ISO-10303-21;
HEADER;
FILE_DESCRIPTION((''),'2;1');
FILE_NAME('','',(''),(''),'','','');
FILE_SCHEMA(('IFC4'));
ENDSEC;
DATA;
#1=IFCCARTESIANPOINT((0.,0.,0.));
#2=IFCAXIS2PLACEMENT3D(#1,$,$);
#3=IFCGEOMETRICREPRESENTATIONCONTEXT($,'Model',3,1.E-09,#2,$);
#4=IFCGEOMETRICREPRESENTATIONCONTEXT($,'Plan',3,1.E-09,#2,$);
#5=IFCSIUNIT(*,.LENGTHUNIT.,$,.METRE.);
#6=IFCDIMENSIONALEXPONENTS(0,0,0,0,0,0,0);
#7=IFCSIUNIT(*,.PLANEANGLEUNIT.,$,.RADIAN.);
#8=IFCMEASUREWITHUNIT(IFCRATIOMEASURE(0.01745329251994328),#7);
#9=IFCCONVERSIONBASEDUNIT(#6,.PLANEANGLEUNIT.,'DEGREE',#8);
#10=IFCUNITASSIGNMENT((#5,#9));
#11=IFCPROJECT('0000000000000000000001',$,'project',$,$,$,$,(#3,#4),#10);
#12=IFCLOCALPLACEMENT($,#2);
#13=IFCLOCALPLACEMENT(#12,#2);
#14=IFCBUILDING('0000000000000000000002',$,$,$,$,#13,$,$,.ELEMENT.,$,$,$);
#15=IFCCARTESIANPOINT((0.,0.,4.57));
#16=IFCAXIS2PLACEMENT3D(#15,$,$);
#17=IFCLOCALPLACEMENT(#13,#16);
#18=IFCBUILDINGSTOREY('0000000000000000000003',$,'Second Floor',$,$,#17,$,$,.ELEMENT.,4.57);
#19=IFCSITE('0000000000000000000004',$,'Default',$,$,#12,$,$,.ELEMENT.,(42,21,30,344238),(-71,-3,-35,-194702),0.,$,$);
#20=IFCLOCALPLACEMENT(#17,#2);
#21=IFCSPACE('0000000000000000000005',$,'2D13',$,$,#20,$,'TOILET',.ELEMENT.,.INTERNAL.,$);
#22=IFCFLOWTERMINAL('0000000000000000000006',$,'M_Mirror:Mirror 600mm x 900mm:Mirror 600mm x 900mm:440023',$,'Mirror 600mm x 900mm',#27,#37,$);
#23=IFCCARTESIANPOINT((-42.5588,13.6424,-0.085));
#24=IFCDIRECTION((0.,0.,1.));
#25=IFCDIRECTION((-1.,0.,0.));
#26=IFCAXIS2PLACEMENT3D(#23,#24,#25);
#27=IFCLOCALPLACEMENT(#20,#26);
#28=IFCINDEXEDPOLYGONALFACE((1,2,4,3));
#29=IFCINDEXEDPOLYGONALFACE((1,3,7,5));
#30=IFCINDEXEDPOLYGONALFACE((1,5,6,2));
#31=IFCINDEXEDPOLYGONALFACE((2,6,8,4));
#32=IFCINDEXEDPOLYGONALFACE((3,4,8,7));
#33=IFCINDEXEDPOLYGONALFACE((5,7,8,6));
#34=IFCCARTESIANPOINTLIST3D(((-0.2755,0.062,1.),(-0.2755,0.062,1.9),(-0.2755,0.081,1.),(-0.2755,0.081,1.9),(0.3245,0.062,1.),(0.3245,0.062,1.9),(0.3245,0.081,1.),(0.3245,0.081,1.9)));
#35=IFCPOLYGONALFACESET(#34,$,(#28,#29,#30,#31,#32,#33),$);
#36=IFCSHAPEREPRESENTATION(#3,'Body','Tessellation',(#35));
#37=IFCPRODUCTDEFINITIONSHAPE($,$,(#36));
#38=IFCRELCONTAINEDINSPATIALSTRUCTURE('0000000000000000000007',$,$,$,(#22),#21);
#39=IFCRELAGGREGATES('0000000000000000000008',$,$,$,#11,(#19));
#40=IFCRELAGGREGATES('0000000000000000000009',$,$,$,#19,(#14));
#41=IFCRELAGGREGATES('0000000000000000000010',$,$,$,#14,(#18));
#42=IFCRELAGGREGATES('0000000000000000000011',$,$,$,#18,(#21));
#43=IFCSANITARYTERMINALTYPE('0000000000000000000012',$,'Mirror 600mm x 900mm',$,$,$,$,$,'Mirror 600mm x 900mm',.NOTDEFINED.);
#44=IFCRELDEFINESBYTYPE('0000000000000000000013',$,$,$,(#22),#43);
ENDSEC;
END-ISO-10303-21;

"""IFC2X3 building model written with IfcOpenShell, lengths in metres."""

from ifc_helpers import new_model, entity, si_unit, converted_unit, frame, origin, origin_2d_with_axis, place, context, project, spatial, rectangle, extrude, source, transform, mapped, type_object, type_shapes, element, save


model = new_model("IFC2X3")

# Units and contexts
model_context = context("Model", 3, precision=1e-09, world=origin())
plan_context = context("Plan", 3, precision=1e-09, world=origin())
ifc_project = project(units=[si_unit("LENGTHUNIT", "METRE"), converted_unit("PLANEANGLEUNIT", "DEGREE", entity("IfcRatioMeasure", 0.01745329251994328), si_unit("PLANEANGLEUNIT", "RADIAN"), dimensions=[0, 0, 0, 0, 0, 0, 0])], contexts=[model_context, plan_context])

# Site, building, storey
site_placement = place(None, origin())
site = spatial("IfcSite", under=ifc_project, at=site_placement, Name="Default", CompositionType="ELEMENT", RefLatitude=(42, 21, 30, 344238), RefLongitude=(-71, -3, -35, -194702), RefElevation=0.0)
building_placement = place(site_placement, origin())
building = spatial("IfcBuilding", under=site, at=building_placement, CompositionType="ELEMENT")
storey_placement = place(building_placement, frame((0.0, 0.0, 4.57)))
storey = spatial("IfcBuildingStorey", under=building, at=storey_placement, Name="Second Floor", CompositionType="ELEMENT", Elevation=4.57)

# Shared definitions
space_placement = place(storey_placement, origin())
space = spatial("IfcSpace", under=storey, at=space_placement, Name="2D13", LongName="TOILET", CompositionType="ELEMENT", InteriorOrExteriorSpace="INTERNAL")

# Flow terminal
sanitary_terminal_type = type_object("IfcSanitaryTerminalType", Name="Mirror 600mm x 900mm", ElementType="Mirror 600mm x 900mm", PredefinedType="NOTDEFINED")
shared_shape_1 = source(origin(), model_context, "Body", "SweptSolid", [
    extrude(rectangle(XDim=0.0191, YDim=0.6, at=origin_2d_with_axis()), frame((0.0245, 0.0715, 1.0), z_axis=(0.0, 0.0, 1.0), x_axis=(0.0, -1.0, 0.0)), (0.0, 0.0, 1.0), 0.9),
])
type_shapes(sanitary_terminal_type, [shared_shape_1])
flow_terminal_placement = place(space_placement, frame((-42.5588, 13.6424, -0.085), z_axis=(0.0, 0.0, 1.0), x_axis=(-1.0, 0.0, 0.0)))
element("IfcFlowTerminal", 1, at=flow_terminal_placement, inside=space, type_object=sanitary_terminal_type, Name="M_Mirror:Mirror 600mm x 900mm:Mirror 600mm x 900mm:440023", ObjectType="Mirror 600mm x 900mm", context=model_context, shape_type="MappedRepresentation", body=[
    mapped(shared_shape_1, transform((0.0, 0.0, 0.0), scale=1.0)),
])

save(model, "model.ifc")
